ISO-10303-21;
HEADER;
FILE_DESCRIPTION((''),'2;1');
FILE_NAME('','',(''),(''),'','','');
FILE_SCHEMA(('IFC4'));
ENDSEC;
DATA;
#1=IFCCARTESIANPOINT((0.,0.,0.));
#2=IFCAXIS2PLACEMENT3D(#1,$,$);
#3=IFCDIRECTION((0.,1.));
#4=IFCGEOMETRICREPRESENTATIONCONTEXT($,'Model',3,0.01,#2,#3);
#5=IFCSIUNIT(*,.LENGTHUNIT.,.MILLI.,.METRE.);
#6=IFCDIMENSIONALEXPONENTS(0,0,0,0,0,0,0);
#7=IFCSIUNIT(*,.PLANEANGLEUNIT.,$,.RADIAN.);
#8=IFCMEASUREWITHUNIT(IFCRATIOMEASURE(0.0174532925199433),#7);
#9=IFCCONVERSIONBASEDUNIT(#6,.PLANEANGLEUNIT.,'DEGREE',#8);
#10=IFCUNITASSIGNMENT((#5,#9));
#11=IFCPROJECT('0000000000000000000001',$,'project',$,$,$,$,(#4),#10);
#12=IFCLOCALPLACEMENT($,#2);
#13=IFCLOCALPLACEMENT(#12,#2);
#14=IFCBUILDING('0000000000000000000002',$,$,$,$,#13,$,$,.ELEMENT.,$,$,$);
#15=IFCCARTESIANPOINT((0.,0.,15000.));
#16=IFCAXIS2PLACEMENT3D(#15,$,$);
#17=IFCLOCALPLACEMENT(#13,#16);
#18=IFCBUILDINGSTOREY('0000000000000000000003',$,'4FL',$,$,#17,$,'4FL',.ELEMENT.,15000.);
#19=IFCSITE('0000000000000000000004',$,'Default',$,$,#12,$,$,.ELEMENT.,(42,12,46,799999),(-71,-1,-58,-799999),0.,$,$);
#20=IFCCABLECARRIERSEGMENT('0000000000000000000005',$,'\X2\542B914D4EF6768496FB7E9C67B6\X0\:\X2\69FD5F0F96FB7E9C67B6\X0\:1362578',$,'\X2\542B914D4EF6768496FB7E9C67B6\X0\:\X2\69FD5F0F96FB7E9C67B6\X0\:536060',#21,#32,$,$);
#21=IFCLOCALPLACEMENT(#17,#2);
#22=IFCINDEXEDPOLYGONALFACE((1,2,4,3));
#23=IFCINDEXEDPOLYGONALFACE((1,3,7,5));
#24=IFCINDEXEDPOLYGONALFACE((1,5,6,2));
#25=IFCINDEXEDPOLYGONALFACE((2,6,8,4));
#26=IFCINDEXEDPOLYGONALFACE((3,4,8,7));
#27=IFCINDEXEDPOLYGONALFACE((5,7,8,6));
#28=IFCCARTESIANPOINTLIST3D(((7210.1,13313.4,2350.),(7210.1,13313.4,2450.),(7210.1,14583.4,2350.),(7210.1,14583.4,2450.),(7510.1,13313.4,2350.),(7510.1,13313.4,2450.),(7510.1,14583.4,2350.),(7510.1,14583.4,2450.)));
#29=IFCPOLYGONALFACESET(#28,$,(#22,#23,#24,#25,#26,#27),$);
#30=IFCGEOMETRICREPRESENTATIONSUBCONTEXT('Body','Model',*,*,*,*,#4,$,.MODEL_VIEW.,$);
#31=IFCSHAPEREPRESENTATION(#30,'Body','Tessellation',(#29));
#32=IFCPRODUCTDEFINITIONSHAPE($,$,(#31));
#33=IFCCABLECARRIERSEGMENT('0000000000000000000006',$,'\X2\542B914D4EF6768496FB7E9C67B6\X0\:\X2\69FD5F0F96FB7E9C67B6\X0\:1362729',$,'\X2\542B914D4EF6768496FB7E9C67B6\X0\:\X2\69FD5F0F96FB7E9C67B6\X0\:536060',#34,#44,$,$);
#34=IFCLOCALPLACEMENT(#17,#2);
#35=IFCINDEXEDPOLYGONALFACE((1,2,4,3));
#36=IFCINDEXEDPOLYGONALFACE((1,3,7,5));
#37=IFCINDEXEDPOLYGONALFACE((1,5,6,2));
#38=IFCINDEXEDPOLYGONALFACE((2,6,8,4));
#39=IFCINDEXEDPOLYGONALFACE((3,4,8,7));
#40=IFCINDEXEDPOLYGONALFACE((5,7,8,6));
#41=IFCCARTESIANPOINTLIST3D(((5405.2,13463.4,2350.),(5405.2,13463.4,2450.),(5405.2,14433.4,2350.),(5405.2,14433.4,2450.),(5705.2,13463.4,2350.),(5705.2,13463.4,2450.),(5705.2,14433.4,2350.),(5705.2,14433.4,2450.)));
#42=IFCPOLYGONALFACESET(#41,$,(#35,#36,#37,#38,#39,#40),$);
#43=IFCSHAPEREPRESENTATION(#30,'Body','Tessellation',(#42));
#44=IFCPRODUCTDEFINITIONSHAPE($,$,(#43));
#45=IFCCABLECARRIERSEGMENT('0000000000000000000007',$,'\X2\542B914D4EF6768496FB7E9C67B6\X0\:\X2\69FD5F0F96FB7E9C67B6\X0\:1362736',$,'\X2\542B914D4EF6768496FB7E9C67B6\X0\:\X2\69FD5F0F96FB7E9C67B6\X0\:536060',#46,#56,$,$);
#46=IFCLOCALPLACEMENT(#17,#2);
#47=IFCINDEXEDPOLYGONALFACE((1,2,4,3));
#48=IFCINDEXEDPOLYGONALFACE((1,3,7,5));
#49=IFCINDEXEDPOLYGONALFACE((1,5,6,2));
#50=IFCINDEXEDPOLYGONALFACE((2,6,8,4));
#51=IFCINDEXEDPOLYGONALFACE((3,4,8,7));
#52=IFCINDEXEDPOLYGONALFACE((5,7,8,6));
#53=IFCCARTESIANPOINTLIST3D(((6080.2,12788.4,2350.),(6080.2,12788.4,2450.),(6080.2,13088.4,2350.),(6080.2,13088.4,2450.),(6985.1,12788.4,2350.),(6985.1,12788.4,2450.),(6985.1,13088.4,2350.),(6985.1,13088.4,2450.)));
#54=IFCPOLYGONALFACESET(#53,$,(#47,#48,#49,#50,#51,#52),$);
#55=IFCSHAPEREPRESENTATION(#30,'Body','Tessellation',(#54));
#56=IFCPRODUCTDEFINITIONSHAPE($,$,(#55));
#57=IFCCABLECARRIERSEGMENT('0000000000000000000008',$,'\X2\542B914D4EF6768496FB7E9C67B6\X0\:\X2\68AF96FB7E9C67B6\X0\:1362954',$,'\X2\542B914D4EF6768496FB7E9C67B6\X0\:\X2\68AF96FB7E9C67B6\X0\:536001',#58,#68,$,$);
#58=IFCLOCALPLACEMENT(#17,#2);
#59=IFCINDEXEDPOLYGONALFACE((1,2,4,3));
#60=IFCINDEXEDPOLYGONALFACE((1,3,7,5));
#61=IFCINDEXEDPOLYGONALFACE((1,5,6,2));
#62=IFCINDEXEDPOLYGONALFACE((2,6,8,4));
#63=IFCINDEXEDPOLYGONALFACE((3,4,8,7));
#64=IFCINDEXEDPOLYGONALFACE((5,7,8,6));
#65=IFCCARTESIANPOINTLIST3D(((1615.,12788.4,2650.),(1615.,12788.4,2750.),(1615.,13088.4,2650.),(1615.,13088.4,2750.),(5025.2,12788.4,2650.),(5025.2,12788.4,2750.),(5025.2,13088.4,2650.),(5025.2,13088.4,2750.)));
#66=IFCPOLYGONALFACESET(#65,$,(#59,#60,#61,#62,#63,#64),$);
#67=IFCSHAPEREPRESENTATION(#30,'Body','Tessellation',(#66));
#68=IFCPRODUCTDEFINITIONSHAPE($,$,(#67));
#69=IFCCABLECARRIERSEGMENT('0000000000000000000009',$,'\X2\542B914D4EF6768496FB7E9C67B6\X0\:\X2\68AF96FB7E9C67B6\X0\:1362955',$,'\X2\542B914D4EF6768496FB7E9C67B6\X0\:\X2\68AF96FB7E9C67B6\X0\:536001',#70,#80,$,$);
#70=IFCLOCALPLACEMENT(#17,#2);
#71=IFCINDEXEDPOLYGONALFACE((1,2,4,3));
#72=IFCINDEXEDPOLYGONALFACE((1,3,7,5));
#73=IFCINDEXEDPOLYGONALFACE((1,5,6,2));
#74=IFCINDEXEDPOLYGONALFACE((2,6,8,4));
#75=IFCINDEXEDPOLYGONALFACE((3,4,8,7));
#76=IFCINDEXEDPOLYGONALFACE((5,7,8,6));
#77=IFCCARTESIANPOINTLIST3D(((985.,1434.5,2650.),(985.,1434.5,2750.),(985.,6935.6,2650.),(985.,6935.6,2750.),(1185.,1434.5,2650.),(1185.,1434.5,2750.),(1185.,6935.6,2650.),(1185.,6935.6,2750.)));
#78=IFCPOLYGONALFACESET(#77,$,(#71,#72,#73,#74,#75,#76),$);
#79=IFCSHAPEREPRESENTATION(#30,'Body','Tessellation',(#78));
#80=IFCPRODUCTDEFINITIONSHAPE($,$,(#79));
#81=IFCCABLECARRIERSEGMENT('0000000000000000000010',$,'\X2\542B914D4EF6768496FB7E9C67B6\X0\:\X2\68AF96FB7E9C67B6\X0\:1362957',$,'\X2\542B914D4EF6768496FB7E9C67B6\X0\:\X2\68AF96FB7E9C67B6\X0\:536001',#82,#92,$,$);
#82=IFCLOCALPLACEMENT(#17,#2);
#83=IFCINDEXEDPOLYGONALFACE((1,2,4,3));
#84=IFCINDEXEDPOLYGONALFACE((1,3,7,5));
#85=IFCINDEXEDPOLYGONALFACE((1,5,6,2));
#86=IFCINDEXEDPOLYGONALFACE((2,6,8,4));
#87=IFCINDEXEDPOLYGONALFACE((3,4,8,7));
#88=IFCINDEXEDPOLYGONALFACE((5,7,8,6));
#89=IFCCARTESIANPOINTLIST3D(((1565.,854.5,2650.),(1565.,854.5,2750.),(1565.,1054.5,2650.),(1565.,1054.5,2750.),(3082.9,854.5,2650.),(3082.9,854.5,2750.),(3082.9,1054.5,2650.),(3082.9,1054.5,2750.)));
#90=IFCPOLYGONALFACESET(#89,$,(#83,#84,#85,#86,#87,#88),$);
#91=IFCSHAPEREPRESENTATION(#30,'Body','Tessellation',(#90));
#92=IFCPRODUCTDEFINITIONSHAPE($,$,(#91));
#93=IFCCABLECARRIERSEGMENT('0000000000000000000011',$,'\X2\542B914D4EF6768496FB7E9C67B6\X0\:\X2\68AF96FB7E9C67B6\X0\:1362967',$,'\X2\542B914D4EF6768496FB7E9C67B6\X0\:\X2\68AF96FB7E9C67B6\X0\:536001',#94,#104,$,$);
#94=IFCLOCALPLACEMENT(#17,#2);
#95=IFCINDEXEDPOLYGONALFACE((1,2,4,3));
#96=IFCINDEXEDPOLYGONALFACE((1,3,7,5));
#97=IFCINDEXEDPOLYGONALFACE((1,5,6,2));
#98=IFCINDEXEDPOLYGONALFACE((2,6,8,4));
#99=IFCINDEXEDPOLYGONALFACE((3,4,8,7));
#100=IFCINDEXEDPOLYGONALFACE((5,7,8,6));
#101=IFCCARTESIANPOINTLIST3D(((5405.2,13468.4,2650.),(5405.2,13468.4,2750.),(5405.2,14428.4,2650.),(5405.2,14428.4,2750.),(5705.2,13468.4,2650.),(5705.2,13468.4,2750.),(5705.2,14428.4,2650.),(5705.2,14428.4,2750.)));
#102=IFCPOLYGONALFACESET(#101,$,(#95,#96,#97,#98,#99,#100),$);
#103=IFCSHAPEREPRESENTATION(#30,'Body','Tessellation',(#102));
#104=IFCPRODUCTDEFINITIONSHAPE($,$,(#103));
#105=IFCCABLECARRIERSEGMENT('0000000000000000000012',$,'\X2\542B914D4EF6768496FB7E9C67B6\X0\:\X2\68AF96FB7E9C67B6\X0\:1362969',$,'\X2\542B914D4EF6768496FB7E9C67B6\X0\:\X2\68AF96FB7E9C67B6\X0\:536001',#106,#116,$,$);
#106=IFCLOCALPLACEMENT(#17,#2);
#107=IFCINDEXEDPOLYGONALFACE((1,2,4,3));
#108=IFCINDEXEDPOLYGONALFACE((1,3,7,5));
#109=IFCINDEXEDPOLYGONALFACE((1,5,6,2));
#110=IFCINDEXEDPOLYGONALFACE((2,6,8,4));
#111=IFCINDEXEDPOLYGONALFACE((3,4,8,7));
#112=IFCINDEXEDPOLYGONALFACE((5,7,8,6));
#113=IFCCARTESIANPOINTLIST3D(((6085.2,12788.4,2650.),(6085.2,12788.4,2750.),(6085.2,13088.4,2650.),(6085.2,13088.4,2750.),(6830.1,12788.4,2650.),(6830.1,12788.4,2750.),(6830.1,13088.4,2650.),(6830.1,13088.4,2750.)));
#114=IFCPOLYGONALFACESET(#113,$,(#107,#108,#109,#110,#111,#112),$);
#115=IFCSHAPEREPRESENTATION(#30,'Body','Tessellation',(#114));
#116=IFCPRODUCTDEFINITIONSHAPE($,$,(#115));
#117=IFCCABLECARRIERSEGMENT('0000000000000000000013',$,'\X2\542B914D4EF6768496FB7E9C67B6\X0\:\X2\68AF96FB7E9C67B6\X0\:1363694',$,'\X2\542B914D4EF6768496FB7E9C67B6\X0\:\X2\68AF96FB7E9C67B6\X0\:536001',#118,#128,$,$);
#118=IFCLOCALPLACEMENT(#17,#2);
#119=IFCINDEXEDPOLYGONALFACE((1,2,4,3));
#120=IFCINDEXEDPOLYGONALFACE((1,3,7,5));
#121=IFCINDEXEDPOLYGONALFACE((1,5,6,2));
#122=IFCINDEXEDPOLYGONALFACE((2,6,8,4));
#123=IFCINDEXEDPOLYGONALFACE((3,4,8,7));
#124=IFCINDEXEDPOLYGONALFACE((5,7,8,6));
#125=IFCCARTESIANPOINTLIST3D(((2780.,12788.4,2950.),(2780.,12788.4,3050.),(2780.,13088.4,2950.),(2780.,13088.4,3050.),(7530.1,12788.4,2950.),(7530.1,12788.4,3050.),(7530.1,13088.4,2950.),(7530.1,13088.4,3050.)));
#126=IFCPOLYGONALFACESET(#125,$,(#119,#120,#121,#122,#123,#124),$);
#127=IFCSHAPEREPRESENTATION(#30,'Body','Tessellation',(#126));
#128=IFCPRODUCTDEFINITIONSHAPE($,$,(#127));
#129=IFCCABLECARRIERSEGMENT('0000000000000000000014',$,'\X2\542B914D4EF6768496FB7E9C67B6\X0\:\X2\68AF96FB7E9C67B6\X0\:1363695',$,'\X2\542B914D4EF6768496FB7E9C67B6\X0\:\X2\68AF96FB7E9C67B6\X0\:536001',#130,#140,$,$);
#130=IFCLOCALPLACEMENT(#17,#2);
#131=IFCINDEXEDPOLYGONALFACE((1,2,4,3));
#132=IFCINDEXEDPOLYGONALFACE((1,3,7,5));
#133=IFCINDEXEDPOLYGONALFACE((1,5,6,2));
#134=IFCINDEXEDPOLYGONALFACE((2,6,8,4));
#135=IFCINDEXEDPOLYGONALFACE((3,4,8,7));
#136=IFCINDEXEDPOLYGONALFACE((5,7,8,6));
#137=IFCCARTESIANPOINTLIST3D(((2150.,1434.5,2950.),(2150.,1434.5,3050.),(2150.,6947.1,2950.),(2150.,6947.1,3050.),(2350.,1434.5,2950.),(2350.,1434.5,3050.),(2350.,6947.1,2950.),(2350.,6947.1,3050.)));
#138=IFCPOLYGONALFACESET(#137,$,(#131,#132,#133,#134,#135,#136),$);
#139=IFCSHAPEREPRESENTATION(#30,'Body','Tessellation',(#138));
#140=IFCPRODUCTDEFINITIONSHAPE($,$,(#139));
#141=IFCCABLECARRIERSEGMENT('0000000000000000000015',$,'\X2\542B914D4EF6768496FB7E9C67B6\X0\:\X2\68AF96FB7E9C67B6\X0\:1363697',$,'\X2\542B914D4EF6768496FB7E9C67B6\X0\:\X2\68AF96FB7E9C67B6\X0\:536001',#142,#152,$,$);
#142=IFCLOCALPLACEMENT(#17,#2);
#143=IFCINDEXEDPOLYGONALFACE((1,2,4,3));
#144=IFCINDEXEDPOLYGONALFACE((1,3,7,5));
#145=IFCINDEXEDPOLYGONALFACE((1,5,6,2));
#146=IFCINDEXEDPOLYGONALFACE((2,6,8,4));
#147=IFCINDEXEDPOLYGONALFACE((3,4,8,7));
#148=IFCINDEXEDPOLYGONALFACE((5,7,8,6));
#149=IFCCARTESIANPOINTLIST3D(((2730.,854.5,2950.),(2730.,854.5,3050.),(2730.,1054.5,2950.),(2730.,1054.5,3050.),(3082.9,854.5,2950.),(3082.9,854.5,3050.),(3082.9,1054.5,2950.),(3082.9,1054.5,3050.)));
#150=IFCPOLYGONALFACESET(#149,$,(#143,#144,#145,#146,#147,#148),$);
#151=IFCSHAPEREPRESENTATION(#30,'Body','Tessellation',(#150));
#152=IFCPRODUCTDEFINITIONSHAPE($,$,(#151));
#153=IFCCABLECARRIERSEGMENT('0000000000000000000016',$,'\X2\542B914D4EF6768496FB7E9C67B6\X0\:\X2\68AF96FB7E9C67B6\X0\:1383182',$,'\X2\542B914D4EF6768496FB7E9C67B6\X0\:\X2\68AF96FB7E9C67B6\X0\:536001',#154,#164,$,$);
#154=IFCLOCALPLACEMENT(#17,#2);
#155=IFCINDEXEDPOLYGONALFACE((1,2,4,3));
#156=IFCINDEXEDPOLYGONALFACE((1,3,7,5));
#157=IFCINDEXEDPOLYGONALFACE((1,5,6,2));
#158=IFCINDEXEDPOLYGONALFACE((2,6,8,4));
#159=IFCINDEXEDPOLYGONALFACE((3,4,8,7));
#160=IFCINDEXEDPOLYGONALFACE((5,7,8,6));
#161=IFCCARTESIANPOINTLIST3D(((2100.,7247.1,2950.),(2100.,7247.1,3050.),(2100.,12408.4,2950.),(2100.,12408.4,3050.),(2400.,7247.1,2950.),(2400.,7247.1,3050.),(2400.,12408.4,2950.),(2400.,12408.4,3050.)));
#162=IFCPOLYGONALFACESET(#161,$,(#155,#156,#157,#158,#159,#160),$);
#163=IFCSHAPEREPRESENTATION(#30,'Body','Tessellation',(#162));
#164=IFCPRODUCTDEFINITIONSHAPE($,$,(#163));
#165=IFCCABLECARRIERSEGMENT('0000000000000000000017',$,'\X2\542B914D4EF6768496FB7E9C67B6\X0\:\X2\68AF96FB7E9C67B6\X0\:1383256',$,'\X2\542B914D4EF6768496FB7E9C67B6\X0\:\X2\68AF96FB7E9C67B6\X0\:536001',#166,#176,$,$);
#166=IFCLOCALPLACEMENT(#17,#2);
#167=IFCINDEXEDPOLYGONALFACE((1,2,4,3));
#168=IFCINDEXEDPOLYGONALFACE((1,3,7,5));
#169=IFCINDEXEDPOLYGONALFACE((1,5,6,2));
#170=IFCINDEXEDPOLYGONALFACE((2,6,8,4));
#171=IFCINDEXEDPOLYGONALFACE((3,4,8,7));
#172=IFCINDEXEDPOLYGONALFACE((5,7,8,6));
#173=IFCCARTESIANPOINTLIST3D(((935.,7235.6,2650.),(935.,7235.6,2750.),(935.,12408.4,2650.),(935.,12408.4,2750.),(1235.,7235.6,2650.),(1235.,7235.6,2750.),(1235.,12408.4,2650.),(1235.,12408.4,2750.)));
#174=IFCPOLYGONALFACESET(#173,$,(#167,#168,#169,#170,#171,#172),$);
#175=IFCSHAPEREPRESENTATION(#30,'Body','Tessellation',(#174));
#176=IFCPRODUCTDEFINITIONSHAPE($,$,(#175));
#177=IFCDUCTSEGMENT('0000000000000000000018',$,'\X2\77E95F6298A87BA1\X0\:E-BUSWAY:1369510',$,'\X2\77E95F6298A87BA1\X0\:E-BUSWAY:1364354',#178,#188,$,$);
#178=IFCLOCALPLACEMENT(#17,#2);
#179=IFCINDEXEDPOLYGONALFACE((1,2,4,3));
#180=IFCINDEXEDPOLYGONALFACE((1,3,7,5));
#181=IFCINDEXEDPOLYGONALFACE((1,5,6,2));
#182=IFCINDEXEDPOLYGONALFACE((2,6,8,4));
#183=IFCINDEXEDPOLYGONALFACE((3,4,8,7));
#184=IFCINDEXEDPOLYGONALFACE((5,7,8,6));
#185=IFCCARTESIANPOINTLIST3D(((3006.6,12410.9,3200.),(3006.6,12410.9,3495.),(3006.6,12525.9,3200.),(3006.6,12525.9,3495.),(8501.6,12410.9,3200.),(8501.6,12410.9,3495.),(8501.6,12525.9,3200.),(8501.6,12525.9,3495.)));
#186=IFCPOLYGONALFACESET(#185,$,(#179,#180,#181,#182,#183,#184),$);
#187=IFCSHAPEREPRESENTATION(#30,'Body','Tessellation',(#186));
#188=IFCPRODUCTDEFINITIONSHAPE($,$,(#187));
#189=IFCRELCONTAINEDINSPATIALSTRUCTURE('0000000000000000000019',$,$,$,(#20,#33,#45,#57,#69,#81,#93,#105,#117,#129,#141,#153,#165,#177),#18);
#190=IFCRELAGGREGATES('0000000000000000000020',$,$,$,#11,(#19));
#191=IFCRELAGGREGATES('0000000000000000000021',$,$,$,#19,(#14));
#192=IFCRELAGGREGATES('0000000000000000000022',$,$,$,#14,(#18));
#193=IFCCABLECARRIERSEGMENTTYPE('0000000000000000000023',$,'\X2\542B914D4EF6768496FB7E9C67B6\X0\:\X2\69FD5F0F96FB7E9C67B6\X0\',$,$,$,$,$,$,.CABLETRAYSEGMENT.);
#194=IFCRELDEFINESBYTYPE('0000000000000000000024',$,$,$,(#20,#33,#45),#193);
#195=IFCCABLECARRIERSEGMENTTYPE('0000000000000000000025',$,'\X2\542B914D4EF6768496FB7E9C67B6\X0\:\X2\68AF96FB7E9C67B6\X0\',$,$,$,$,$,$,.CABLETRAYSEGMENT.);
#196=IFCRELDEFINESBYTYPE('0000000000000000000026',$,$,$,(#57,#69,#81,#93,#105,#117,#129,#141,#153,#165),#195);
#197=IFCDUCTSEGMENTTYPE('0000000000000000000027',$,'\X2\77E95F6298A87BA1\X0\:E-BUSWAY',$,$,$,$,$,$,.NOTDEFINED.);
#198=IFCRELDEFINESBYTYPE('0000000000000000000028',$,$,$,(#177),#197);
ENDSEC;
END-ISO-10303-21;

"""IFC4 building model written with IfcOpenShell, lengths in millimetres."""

from ifc_helpers import new_model, entity, si_unit, converted_unit, direction, frame, frame_2d, origin, origin_2d_with_axis, place, context, subcontext, project, spatial, rectangle, extrude, type_object, element, save


model = new_model("IFC4")

# Units and contexts
model_context = context("Model", 3, precision=0.01, world=origin(), true_north=direction((0.0, 1.0)))
body_context = subcontext(model_context, "Body", "Model", "MODEL_VIEW")
ifc_project = project(units=[si_unit("LENGTHUNIT", "METRE", prefix="MILLI"), converted_unit("PLANEANGLEUNIT", "DEGREE", entity("IfcRatioMeasure", 0.0174532925199433), si_unit("PLANEANGLEUNIT", "RADIAN"), dimensions=[0, 0, 0, 0, 0, 0, 0])], contexts=[model_context])

# Site, building, storey
site_placement = place(None, origin())
site = spatial("IfcSite", under=ifc_project, at=site_placement, Name="Default", CompositionType="ELEMENT", RefLatitude=(42, 12, 46, 799999), RefLongitude=(-71, -1, -58, -799999), RefElevation=0.0)
building_placement = place(site_placement, origin())
building = spatial("IfcBuilding", under=site, at=building_placement, CompositionType="ELEMENT")
storey_placement = place(building_placement, frame((0.0, 0.0, 15000.0)))
storey = spatial("IfcBuildingStorey", under=building, at=storey_placement, Name="4FL", LongName="4FL", CompositionType="ELEMENT", Elevation=15000.0)

# Cable carrier segments
cable_carrier_segment_type_1 = type_object("IfcCableCarrierSegmentType", Name="含配件的電纜架:槽式電纜架", PredefinedType="CABLETRAYSEGMENT")
cable_carrier_segment_1_placement = place(storey_placement, frame((7210.1, 13313.4, 2350.0)))
element("IfcCableCarrierSegment", 1, at=cable_carrier_segment_1_placement, inside=storey, type_object=cable_carrier_segment_type_1, Name="含配件的電纜架:槽式電纜架:1362578", ObjectType="含配件的電纜架:槽式電纜架:536060", context=body_context, shape_type="SweptSolid", body=[
    extrude(rectangle(XDim=1270.0, YDim=300.0, at=frame_2d((0.0, 0.0), x_axis=(1.0, 0.0))), frame((150.0, 635.0, 0.0), z_axis=(0.0, 0.0, 1.0), x_axis=(0.0, -1.0, 0.0)), (0.0, 0.0, 1.0), 100.0),
])
cable_carrier_segment_2_placement = place(storey_placement, frame((5405.2, 13463.4, 2350.0)))
element("IfcCableCarrierSegment", 2, at=cable_carrier_segment_2_placement, inside=storey, type_object=cable_carrier_segment_type_1, Name="含配件的電纜架:槽式電纜架:1362729", ObjectType="含配件的電纜架:槽式電纜架:536060", context=body_context, shape_type="SweptSolid", body=[
    extrude(rectangle(XDim=970.0, YDim=300.0, at=frame_2d((0.0, 0.0), x_axis=(1.0, 0.0))), frame((150.0, 485.0, 0.0), z_axis=(0.0, 0.0, 1.0), x_axis=(0.0, -1.0, 0.0)), (0.0, 0.0, 1.0), 100.0),
])
cable_carrier_segment_3_placement = place(storey_placement, frame((6080.2, 12788.4, 2350.0)))
element("IfcCableCarrierSegment", 3, at=cable_carrier_segment_3_placement, inside=storey, type_object=cable_carrier_segment_type_1, Name="含配件的電纜架:槽式電纜架:1362736", ObjectType="含配件的電纜架:槽式電纜架:536060", context=body_context, shape_type="SweptSolid", body=[
    extrude(rectangle(XDim=904.9, YDim=300.0, at=frame_2d((0.0, 0.0), x_axis=(1.0, 0.0))), frame((452.4, 150.0, 0.0), z_axis=(0.0, 0.0, 1.0), x_axis=(-1.0, 0.0, 0.0)), (0.0, 0.0, 1.0), 100.0),
])
cable_carrier_segment_type_2 = type_object("IfcCableCarrierSegmentType", Name="含配件的電纜架:梯電纜架", PredefinedType="CABLETRAYSEGMENT")
cable_carrier_segment_4_placement = place(storey_placement, frame((1615.0, 12788.4, 2650.0)))
element("IfcCableCarrierSegment", 4, at=cable_carrier_segment_4_placement, inside=storey, type_object=cable_carrier_segment_type_2, Name="含配件的電纜架:梯電纜架:1362954", ObjectType="含配件的電纜架:梯電纜架:536001", context=body_context, shape_type="SweptSolid", body=[
    extrude(rectangle(XDim=3410.2, YDim=300.0, at=origin_2d_with_axis()), frame((1705.1, 150.0, 0.0), z_axis=(0.0, 0.0, 1.0), x_axis=(-1.0, 0.0, 0.0)), (0.0, 0.0, 1.0), 100.0),
])
cable_carrier_segment_5_placement = place(storey_placement, frame((985.0, 1434.5, 2650.0)))
element("IfcCableCarrierSegment", 5, at=cable_carrier_segment_5_placement, inside=storey, type_object=cable_carrier_segment_type_2, Name="含配件的電纜架:梯電纜架:1362955", ObjectType="含配件的電纜架:梯電纜架:536001", context=body_context, shape_type="SweptSolid", body=[
    extrude(rectangle(XDim=5501.1, YDim=200.0, at=origin_2d_with_axis()), frame((100.0, 2750.5, 0.0), z_axis=(0.0, 0.0, 1.0), x_axis=(0.0, -1.0, 0.0)), (0.0, 0.0, 1.0), 100.0),
])
cable_carrier_segment_6_placement = place(storey_placement, frame((1565.0, 854.5, 2650.0)))
element("IfcCableCarrierSegment", 6, at=cable_carrier_segment_6_placement, inside=storey, type_object=cable_carrier_segment_type_2, Name="含配件的電纜架:梯電纜架:1362957", ObjectType="含配件的電纜架:梯電纜架:536001", context=body_context, shape_type="SweptSolid", body=[
    extrude(rectangle(XDim=1517.9, YDim=200.0, at=frame_2d((0.0, 0.0), x_axis=(1.0, 0.0))), frame((759.0, 100.0, 0.0)), (0.0, 0.0, 1.0), 100.0),
])
cable_carrier_segment_7_placement = place(storey_placement, frame((5405.2, 13468.4, 2650.0)))
element("IfcCableCarrierSegment", 7, at=cable_carrier_segment_7_placement, inside=storey, type_object=cable_carrier_segment_type_2, Name="含配件的電纜架:梯電纜架:1362967", ObjectType="含配件的電纜架:梯電纜架:536001", context=body_context, shape_type="SweptSolid", body=[
    extrude(rectangle(XDim=960.0, YDim=300.0, at=frame_2d((0.0, 0.0), x_axis=(1.0, 0.0))), frame((150.0, 480.0, 0.0), z_axis=(0.0, 0.0, 1.0), x_axis=(0.0, -1.0, 0.0)), (0.0, 0.0, 1.0), 100.0),
])
cable_carrier_segment_8_placement = place(storey_placement, frame((6085.2, 12788.4, 2650.0)))
element("IfcCableCarrierSegment", 8, at=cable_carrier_segment_8_placement, inside=storey, type_object=cable_carrier_segment_type_2, Name="含配件的電纜架:梯電纜架:1362969", ObjectType="含配件的電纜架:梯電纜架:536001", context=body_context, shape_type="SweptSolid", body=[
    extrude(rectangle(XDim=744.9, YDim=300.0, at=frame_2d((0.0, 0.0), x_axis=(1.0, 0.0))), frame((372.4, 150.0, 0.0), z_axis=(0.0, 0.0, 1.0), x_axis=(-1.0, 0.0, 0.0)), (0.0, 0.0, 1.0), 100.0),
])
cable_carrier_segment_9_placement = place(storey_placement, frame((2780.0, 12788.4, 2950.0)))
element("IfcCableCarrierSegment", 9, at=cable_carrier_segment_9_placement, inside=storey, type_object=cable_carrier_segment_type_2, Name="含配件的電纜架:梯電纜架:1363694", ObjectType="含配件的電纜架:梯電纜架:536001", context=body_context, shape_type="SweptSolid", body=[
    extrude(rectangle(XDim=4750.1, YDim=300.0, at=frame_2d((0.0, 0.0), x_axis=(1.0, 0.0))), frame((2375.0, 150.0, 0.0), z_axis=(0.0, 0.0, 1.0), x_axis=(-1.0, 0.0, 0.0)), (0.0, 0.0, 1.0), 100.0),
])
cable_carrier_segment_10_placement = place(storey_placement, frame((2150.0, 1434.5, 2950.0)))
element("IfcCableCarrierSegment", 10, at=cable_carrier_segment_10_placement, inside=storey, type_object=cable_carrier_segment_type_2, Name="含配件的電纜架:梯電纜架:1363695", ObjectType="含配件的電纜架:梯電纜架:536001", context=body_context, shape_type="SweptSolid", body=[
    extrude(rectangle(XDim=5512.6, YDim=200.0, at=frame_2d((0.0, 0.0), x_axis=(1.0, 0.0))), frame((100.0, 2756.3, 0.0), z_axis=(0.0, 0.0, 1.0), x_axis=(0.0, -1.0, 0.0)), (0.0, 0.0, 1.0), 100.0),
])
cable_carrier_segment_11_placement = place(storey_placement, frame((2730.0, 854.5, 2950.0)))
element("IfcCableCarrierSegment", 11, at=cable_carrier_segment_11_placement, inside=storey, type_object=cable_carrier_segment_type_2, Name="含配件的電纜架:梯電纜架:1363697", ObjectType="含配件的電纜架:梯電纜架:536001", context=body_context, shape_type="SweptSolid", body=[
    extrude(rectangle(XDim=352.9, YDim=200.0, at=origin_2d_with_axis()), frame((176.5, 100.0, 0.0)), (0.0, 0.0, 1.0), 100.0),
])
cable_carrier_segment_12_placement = place(storey_placement, frame((2100.0, 7247.1, 2950.0)))
element("IfcCableCarrierSegment", 12, at=cable_carrier_segment_12_placement, inside=storey, type_object=cable_carrier_segment_type_2, Name="含配件的電纜架:梯電纜架:1383182", ObjectType="含配件的電纜架:梯電纜架:536001", context=body_context, shape_type="SweptSolid", body=[
    extrude(rectangle(XDim=5161.2, YDim=300.0, at=frame_2d((0.0, 0.0), x_axis=(1.0, 0.0))), frame((150.0, 2580.6, 0.0), z_axis=(0.0, 0.0, 1.0), x_axis=(0.0, -1.0, 0.0)), (0.0, 0.0, 1.0), 100.0),
])
cable_carrier_segment_13_placement = place(storey_placement, frame((935.0, 7235.6, 2650.0)))
element("IfcCableCarrierSegment", 13, at=cable_carrier_segment_13_placement, inside=storey, type_object=cable_carrier_segment_type_2, Name="含配件的電纜架:梯電纜架:1383256", ObjectType="含配件的電纜架:梯電纜架:536001", context=body_context, shape_type="SweptSolid", body=[
    extrude(rectangle(XDim=5172.8, YDim=300.0, at=frame_2d((0.0, 0.0), x_axis=(1.0, 0.0))), frame((150.0, 2586.4, 0.0), z_axis=(0.0, 0.0, 1.0), x_axis=(0.0, -1.0, 0.0)), (0.0, 0.0, 1.0), 100.0),
])

# Duct segment
duct_segment_type = type_object("IfcDuctSegmentType", Name="矩形風管:E-BUSWAY", PredefinedType="NOTDEFINED")
duct_segment_1_placement = place(storey_placement, frame((3006.6, 12410.9, 3200.0)))
element("IfcDuctSegment", 14, at=duct_segment_1_placement, inside=storey, type_object=duct_segment_type, Name="矩形風管:E-BUSWAY:1369510", ObjectType="矩形風管:E-BUSWAY:1364354", context=body_context, shape_type="SweptSolid", body=[
    extrude(rectangle(XDim=5495.0, YDim=115.0, at=origin_2d_with_axis()), frame((2747.5, 57.5, 0.0), z_axis=(0.0, 0.0, 1.0), x_axis=(-1.0, 0.0, 0.0)), (0.0, 0.0, 1.0), 295.0),
])

save(model, "model.ifc")
